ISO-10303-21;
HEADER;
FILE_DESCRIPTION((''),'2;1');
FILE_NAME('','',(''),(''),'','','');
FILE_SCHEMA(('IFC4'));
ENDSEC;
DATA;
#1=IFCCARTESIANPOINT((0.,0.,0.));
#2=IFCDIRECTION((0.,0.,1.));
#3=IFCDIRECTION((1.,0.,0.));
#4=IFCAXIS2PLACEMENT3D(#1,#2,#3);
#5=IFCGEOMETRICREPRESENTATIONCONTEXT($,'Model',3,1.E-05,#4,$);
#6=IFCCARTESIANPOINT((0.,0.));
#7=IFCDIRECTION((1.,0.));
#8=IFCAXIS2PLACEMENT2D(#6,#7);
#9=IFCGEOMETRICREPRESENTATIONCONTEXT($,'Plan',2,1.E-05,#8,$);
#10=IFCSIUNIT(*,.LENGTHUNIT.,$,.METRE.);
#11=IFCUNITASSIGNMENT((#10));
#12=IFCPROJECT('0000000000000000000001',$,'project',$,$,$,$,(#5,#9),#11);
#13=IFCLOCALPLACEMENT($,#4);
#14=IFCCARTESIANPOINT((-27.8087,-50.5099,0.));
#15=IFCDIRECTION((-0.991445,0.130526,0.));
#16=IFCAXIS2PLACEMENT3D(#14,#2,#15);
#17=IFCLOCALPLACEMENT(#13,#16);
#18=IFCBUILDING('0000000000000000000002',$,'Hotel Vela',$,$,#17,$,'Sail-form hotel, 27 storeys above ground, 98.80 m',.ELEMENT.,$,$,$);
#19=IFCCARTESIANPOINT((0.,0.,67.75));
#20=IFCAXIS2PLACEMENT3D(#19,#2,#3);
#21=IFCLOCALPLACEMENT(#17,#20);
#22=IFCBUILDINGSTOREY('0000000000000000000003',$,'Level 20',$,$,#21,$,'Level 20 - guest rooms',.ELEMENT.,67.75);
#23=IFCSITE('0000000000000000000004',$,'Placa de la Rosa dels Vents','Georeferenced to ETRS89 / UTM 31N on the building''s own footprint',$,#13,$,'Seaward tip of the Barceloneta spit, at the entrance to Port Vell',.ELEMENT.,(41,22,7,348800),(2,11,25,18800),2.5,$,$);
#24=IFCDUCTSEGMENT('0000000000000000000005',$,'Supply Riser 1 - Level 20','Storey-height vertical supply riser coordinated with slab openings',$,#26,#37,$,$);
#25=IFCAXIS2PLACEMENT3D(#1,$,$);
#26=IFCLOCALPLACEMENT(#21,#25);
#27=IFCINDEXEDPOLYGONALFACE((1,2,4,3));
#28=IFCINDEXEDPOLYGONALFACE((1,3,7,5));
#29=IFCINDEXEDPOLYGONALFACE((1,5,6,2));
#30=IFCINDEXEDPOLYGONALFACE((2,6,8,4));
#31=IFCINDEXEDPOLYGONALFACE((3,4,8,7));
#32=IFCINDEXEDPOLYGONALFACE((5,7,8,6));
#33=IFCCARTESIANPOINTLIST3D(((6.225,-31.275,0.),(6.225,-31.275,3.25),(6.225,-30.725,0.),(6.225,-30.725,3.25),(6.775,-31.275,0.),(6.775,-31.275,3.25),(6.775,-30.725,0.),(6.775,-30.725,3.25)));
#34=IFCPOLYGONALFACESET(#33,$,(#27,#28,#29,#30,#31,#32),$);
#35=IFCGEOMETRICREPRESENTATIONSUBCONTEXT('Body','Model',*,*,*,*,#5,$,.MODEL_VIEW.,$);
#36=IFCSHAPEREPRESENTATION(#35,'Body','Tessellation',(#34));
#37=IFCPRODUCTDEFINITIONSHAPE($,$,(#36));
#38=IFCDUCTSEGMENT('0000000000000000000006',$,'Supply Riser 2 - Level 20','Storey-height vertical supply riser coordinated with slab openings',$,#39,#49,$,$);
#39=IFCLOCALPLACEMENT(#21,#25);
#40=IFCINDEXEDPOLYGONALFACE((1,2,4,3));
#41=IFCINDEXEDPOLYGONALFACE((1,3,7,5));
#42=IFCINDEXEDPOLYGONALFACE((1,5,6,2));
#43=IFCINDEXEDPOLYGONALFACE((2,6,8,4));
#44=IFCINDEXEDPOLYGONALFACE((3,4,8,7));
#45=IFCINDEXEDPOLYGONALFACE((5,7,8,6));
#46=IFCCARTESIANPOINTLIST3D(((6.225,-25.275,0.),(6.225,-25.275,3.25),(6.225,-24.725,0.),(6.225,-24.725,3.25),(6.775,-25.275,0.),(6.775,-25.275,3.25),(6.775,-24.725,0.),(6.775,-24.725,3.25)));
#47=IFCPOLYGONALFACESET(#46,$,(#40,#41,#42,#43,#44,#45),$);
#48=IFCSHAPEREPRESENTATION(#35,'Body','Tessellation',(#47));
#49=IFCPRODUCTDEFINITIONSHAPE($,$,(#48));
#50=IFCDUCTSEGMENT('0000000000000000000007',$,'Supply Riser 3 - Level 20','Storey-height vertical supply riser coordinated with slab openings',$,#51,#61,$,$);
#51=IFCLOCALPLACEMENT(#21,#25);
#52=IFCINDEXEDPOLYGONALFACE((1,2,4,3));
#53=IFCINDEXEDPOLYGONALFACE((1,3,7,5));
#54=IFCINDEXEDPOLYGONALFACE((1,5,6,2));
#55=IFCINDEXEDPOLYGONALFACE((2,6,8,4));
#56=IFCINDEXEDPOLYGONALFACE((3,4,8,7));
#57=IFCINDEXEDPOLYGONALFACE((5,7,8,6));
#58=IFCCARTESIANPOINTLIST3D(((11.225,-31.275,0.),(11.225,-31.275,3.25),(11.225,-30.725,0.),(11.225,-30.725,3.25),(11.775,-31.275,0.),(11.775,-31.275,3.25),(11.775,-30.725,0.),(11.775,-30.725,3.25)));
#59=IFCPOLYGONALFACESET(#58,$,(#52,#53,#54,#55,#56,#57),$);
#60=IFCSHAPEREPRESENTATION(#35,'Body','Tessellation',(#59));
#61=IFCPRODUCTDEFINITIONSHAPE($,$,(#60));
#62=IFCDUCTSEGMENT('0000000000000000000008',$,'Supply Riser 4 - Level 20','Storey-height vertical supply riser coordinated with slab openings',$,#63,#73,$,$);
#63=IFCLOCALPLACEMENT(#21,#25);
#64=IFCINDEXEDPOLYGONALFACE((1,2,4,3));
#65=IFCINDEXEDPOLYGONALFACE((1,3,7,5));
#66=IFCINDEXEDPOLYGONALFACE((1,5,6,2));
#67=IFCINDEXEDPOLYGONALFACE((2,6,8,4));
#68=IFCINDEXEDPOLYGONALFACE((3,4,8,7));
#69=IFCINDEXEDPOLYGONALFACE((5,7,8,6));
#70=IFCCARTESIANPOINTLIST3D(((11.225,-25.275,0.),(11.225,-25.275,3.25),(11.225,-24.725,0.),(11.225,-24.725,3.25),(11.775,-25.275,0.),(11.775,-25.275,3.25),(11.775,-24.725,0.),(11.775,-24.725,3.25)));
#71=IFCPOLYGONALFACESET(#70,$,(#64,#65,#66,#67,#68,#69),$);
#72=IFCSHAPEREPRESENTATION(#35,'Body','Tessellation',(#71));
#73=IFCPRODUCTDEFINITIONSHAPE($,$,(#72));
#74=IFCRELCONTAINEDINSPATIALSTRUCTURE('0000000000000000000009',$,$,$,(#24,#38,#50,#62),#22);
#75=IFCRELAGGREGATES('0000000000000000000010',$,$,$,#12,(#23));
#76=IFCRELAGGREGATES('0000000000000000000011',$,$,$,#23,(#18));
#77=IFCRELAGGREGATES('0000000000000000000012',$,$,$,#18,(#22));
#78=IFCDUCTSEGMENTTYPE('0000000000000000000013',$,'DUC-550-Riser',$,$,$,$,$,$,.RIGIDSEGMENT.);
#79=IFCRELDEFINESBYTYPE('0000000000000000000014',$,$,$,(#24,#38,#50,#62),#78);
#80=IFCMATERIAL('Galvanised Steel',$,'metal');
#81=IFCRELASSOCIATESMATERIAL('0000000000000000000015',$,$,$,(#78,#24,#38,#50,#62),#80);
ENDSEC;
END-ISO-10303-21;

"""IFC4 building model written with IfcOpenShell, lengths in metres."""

from ifc_helpers import new_model, si_unit, frame, origin_with_axes, origin_2d_with_axis, place, context, subcontext, project, spatial, line, indexed_curve, outline, extrude, material, type_object, element, save


model = new_model("IFC4")

# Units and contexts
model_context = context("Model", 3, precision=1e-05, world=origin_with_axes())
plan_context = context("Plan", 2, precision=1e-05, world=origin_2d_with_axis())
body_context = subcontext(model_context, "Body", "Model", "MODEL_VIEW")
ifc_project = project(units=[si_unit("LENGTHUNIT", "METRE")], contexts=[model_context, plan_context])

# Site, building, storey
site_placement = place(None, origin_with_axes())
site = spatial("IfcSite", under=ifc_project, at=site_placement, Name="Placa de la Rosa dels Vents", Description="Georeferenced to ETRS89 / UTM 31N on the building's own footprint", LongName="Seaward tip of the Barceloneta spit, at the entrance to Port Vell", CompositionType="ELEMENT", RefLatitude=(41, 22, 7, 348800), RefLongitude=(2, 11, 25, 18800), RefElevation=2.5)
building_placement = place(site_placement, frame((-27.8087, -50.5099, 0.0), z_axis=(0.0, 0.0, 1.0), x_axis=(-0.991445, 0.130526, 0.0)))
building = spatial("IfcBuilding", under=site, at=building_placement, Name="Hotel Vela", LongName="Sail-form hotel, 27 storeys above ground, 98.80 m", CompositionType="ELEMENT")
storey_placement = place(building_placement, frame((0.0, 0.0, 67.75), z_axis=(0.0, 0.0, 1.0), x_axis=(1.0, 0.0, 0.0)))
storey = spatial("IfcBuildingStorey", under=building, at=storey_placement, Name="Level 20", LongName="Level 20 - guest rooms", CompositionType="ELEMENT", Elevation=67.75)

# Duct segments
ifc_material = material(Name="Galvanised Steel", Category="metal")
duct_segment_type = type_object("IfcDuctSegmentType", Name="DUC-550-Riser", PredefinedType="RIGIDSEGMENT", material=ifc_material)
for number, where, z_axis, x_axis, name in (
    (1, (6.225, -31.275, 0.0), (0.0, 0.0, 1.0), (1.0, 0.0, 0.0), "Supply Riser 1 - Level 20"),
    (2, (6.225, -25.275, 0.0), (0.0, 0.0, 1.0), (1.0, 0.0, 0.0), "Supply Riser 2 - Level 20"),
    (3, (11.225, -31.275, 0.0), (0.0, 0.0, 1.0), (1.0, 0.0, 0.0), "Supply Riser 3 - Level 20"),
    (4, (11.225, -25.275, 0.0), (0.0, 0.0, 1.0), (1.0, 0.0, 0.0), "Supply Riser 4 - Level 20"),
):
    element("IfcDuctSegment", number, at=place(storey_placement, frame(where, z_axis=z_axis, x_axis=x_axis)), inside=storey, type_object=duct_segment_type, material=ifc_material, Name=name, Description="Storey-height vertical supply riser coordinated with slab openings", context=body_context, shape_type="SweptSolid", body=[
        extrude(outline(indexed_curve([(0.0, 0.0), (0.55, 0.0), (0.55, 0.55), (0.0, 0.55)], segments=[line(1, 2, 3, 4, 1)])), origin_with_axes(), (0.0, 0.0, 1.0), 3.25),
    ])

save(model, "model.ifc")
